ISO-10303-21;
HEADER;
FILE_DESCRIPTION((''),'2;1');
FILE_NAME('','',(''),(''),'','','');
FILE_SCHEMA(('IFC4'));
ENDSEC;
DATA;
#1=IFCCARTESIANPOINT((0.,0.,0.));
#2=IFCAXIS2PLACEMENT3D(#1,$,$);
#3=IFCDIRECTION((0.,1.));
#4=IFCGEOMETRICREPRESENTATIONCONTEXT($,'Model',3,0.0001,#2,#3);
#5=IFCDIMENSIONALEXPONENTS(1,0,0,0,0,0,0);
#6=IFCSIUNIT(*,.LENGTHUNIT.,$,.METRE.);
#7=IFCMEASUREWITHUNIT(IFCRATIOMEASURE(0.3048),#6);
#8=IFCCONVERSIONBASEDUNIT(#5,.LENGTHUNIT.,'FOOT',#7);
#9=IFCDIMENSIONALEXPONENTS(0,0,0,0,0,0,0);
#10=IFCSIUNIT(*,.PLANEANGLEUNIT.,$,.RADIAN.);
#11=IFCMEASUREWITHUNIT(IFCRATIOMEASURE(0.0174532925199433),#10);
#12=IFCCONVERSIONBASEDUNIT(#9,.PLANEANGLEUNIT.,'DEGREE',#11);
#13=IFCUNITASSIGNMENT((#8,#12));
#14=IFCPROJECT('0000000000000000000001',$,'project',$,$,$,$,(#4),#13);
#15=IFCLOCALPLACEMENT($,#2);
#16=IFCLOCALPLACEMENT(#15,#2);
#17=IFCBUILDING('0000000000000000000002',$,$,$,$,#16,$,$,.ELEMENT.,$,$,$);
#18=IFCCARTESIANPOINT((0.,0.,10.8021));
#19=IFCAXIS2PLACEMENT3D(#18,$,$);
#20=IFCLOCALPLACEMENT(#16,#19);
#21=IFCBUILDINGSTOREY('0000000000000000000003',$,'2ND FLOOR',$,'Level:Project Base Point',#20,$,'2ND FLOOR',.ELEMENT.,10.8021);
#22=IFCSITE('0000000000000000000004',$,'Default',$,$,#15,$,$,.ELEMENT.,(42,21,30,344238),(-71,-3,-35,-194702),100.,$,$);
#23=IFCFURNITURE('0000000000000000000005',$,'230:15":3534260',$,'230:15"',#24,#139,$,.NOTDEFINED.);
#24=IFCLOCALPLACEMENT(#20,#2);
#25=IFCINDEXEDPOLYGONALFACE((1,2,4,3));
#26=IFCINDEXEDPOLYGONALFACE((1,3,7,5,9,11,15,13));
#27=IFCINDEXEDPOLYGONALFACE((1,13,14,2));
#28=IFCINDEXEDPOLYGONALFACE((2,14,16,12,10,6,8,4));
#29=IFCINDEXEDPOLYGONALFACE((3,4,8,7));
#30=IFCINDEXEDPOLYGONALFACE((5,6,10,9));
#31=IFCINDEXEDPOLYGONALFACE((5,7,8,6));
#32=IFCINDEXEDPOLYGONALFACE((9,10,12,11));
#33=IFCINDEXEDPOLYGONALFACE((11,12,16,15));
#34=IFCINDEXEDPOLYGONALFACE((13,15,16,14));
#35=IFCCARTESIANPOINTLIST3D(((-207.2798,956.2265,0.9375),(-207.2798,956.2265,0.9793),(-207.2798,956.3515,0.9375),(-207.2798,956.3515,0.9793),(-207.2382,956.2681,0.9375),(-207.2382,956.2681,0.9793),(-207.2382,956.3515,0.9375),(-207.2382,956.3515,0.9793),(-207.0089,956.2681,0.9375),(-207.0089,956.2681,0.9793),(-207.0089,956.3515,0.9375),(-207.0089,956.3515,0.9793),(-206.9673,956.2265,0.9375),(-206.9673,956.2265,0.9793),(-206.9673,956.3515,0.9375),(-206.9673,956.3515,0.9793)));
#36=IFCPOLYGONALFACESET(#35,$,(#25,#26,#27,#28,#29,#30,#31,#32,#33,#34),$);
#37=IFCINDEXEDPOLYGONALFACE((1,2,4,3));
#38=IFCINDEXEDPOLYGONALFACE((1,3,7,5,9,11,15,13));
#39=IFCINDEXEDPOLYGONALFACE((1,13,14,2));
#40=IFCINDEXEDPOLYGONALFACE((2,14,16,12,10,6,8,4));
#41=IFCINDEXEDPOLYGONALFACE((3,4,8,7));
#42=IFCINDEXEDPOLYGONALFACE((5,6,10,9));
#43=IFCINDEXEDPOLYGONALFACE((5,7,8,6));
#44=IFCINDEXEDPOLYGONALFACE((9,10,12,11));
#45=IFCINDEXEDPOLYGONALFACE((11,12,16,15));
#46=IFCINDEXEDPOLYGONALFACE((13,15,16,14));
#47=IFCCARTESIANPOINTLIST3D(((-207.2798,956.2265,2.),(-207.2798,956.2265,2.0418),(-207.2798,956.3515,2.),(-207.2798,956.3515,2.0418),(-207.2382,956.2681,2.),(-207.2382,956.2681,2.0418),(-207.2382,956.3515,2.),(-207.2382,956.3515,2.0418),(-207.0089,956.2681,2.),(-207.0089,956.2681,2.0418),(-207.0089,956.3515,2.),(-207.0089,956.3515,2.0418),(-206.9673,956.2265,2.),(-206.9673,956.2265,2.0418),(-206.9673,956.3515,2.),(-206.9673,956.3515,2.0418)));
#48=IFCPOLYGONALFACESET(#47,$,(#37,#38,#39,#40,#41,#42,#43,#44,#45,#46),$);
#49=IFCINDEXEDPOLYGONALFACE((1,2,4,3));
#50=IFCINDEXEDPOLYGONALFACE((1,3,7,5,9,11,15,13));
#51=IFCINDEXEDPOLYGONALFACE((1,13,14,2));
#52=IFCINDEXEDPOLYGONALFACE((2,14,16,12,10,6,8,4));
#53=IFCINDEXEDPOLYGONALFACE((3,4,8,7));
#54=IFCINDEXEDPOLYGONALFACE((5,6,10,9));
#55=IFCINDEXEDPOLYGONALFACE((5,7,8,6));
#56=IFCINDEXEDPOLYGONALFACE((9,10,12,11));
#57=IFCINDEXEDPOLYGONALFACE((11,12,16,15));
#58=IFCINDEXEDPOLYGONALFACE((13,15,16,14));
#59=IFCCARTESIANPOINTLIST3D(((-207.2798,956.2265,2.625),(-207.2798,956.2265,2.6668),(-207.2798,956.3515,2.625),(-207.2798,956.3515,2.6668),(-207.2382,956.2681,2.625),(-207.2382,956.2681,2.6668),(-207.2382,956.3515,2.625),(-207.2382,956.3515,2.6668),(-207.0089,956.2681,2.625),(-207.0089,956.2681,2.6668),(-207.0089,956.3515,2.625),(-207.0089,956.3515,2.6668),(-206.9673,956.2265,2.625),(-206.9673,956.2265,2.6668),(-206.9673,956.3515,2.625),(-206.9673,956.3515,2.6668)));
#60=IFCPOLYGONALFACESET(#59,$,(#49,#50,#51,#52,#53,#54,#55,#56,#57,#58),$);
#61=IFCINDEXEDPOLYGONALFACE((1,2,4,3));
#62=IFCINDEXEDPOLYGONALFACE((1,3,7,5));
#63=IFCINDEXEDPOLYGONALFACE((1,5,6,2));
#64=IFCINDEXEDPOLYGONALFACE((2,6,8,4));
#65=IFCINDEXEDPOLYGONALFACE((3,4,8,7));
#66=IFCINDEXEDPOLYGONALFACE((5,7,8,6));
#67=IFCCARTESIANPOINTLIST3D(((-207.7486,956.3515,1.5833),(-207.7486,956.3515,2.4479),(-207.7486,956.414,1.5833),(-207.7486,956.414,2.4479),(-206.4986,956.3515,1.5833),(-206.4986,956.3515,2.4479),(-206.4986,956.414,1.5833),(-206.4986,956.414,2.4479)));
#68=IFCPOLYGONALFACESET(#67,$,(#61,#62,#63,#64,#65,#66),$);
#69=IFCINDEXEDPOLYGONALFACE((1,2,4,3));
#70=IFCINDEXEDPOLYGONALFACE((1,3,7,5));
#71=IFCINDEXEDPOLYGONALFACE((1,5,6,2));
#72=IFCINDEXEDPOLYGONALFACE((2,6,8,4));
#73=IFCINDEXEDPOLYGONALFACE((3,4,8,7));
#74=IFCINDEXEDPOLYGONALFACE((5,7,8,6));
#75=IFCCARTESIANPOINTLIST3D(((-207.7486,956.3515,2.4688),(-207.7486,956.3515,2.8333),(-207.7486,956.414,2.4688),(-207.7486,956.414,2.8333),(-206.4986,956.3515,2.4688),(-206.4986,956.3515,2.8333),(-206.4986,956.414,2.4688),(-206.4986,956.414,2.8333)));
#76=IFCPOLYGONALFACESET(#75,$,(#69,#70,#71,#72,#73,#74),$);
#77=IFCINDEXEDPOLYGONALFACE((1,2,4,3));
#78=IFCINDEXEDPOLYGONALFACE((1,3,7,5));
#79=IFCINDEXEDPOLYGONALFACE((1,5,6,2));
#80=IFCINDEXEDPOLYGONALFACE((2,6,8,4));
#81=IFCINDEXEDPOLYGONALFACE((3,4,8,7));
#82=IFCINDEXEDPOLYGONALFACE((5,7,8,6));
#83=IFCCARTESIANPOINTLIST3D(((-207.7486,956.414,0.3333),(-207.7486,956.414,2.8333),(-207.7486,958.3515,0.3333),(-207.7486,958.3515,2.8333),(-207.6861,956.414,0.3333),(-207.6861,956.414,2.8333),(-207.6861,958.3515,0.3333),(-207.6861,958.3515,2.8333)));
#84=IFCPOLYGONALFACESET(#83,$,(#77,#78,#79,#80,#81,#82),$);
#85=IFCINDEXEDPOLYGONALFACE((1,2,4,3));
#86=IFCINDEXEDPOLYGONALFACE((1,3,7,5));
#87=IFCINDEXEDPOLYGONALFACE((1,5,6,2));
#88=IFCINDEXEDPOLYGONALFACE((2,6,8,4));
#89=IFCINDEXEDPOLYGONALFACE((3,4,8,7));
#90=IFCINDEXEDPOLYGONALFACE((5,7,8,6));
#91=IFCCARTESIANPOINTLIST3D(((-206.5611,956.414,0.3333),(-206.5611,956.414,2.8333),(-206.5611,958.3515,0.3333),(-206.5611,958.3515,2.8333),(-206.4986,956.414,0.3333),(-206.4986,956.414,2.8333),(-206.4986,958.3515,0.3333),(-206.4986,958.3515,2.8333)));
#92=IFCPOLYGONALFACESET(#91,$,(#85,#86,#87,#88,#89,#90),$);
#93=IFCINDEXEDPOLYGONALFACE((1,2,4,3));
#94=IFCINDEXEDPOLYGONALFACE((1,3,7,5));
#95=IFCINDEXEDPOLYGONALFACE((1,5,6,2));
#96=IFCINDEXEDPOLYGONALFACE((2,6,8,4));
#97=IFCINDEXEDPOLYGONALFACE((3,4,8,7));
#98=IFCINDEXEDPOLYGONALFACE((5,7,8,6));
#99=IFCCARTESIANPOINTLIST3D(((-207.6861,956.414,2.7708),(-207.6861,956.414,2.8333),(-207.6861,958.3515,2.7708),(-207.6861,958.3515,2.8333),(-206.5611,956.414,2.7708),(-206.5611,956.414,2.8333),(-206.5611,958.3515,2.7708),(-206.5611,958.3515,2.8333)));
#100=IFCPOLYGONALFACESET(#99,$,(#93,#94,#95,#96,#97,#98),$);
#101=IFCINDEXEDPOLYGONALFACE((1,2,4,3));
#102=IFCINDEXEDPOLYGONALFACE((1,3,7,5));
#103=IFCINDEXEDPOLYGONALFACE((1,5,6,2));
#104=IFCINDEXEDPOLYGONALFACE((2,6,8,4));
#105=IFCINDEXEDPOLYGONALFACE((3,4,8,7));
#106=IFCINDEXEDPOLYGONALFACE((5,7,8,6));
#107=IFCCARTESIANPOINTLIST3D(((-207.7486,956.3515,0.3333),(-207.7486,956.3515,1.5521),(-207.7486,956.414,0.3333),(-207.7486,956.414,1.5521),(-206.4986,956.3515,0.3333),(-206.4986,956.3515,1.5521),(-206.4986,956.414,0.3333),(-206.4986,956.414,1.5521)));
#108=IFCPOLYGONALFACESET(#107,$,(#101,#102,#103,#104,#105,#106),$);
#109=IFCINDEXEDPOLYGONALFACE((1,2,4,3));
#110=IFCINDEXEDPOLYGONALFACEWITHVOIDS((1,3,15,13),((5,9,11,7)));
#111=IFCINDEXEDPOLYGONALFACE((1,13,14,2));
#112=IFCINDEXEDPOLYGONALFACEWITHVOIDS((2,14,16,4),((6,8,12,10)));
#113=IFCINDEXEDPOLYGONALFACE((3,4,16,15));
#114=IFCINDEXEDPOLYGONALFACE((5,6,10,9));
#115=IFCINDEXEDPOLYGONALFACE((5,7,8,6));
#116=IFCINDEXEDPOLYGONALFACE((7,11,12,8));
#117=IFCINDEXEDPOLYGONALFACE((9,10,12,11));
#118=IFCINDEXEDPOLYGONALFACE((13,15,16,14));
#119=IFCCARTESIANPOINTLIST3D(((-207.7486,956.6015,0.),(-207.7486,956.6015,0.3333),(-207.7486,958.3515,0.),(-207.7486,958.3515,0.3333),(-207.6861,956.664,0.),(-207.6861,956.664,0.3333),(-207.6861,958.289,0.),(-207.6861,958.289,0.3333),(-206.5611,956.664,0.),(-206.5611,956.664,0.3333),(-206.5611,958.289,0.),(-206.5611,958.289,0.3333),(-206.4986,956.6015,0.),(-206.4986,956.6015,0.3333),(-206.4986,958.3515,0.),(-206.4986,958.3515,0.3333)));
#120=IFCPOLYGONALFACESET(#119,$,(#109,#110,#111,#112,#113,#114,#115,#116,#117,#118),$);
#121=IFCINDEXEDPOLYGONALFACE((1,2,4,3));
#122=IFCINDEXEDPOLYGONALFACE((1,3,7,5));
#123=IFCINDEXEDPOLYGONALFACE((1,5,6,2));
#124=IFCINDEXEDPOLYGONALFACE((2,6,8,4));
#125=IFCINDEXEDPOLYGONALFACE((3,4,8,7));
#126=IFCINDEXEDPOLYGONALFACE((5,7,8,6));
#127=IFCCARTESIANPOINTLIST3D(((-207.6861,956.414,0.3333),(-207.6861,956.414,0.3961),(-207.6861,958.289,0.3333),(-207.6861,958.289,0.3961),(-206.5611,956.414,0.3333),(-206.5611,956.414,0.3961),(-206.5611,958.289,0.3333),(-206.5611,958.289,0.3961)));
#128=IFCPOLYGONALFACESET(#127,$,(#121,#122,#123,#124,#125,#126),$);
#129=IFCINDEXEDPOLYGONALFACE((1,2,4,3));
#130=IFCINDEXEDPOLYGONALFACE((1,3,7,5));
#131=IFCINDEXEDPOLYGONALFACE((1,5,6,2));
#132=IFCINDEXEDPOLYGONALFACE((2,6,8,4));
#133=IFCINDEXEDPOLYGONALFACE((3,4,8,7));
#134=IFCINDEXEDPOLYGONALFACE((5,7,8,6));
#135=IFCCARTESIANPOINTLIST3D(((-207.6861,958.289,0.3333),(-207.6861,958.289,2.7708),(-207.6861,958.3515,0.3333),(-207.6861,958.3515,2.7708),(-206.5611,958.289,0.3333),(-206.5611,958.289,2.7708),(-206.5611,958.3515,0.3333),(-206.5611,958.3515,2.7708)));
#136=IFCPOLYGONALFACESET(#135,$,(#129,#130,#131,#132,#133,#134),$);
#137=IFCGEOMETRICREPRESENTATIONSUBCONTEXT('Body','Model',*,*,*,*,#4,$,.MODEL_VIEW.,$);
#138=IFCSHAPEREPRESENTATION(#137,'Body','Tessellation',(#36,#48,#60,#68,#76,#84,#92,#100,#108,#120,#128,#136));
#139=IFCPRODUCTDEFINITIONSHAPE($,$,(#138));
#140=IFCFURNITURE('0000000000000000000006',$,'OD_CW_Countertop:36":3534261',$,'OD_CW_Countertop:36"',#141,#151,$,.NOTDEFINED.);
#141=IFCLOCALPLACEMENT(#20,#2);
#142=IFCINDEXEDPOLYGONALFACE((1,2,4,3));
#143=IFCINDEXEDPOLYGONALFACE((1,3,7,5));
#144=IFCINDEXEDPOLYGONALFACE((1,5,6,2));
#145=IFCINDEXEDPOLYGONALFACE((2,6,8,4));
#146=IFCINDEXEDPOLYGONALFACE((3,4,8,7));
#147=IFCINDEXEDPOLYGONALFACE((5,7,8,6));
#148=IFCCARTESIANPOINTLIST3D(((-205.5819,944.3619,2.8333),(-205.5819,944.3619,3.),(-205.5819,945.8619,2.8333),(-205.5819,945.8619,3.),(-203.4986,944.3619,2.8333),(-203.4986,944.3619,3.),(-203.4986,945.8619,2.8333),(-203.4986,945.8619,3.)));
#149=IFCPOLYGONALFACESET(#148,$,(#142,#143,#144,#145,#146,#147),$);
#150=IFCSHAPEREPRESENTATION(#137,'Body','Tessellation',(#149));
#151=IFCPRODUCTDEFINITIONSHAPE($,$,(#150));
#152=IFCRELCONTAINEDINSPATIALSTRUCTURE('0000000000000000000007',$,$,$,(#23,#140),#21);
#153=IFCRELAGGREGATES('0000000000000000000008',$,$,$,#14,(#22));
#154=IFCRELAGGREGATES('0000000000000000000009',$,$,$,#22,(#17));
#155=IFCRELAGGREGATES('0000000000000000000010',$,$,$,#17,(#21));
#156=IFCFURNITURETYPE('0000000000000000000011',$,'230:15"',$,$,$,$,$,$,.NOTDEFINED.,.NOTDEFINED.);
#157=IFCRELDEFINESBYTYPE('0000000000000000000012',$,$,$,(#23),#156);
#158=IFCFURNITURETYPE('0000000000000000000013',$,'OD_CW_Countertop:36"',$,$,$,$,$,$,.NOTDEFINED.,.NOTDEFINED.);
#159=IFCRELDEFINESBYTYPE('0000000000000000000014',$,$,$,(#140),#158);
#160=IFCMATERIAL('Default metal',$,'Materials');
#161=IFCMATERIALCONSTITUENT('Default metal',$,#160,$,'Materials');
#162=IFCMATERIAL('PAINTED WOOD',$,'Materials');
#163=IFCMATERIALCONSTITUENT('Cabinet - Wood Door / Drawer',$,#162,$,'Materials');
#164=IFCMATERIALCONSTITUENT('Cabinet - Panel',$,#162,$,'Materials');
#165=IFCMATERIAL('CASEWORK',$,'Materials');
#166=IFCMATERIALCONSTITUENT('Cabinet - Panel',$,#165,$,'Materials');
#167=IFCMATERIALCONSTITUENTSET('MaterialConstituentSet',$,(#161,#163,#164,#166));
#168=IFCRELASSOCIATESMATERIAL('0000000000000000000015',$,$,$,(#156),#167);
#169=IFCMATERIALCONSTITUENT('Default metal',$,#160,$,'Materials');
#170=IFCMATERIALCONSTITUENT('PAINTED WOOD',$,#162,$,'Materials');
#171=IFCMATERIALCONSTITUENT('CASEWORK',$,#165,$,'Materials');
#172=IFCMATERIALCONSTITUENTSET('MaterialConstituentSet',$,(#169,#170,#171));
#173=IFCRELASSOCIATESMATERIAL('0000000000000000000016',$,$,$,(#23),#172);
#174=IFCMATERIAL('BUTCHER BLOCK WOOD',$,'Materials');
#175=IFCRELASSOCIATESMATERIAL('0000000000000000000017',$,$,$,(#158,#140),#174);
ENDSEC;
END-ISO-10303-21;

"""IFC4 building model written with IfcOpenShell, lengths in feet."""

from ifc_helpers import new_model, entity, si_unit, converted_unit, direction, frame, frame_2d, origin, origin_2d_with_axis, place, context, subcontext, project, spatial, polyline, rectangle, outline, extrude, source, transform, mapped, material, constituent, constituent_set, type_object, type_shapes, element, save


model = new_model("IFC4")

# Units and contexts
model_context = context("Model", 3, precision=0.0001, world=origin(), true_north=direction((0.0, 1.0)))
body_context = subcontext(model_context, "Body", "Model", "MODEL_VIEW")
ifc_project = project(units=[converted_unit("LENGTHUNIT", "FOOT", entity("IfcRatioMeasure", 0.3048), si_unit("LENGTHUNIT", "METRE"), dimensions=[1, 0, 0, 0, 0, 0, 0]), converted_unit("PLANEANGLEUNIT", "DEGREE", entity("IfcRatioMeasure", 0.0174532925199433), si_unit("PLANEANGLEUNIT", "RADIAN"), dimensions=[0, 0, 0, 0, 0, 0, 0])], contexts=[model_context])

# Site, building, storey
site_placement = place(None, origin())
site = spatial("IfcSite", under=ifc_project, at=site_placement, Name="Default", CompositionType="ELEMENT", RefLatitude=(42, 21, 30, 344238), RefLongitude=(-71, -3, -35, -194702), RefElevation=100.0)
building_placement = place(site_placement, origin())
building = spatial("IfcBuilding", under=site, at=building_placement, CompositionType="ELEMENT")
storey_placement = place(building_placement, frame((0.0, 0.0, 10.8021)))
storey = spatial("IfcBuildingStorey", under=building, at=storey_placement, Name="2ND FLOOR", ObjectType="Level:Project Base Point", LongName="2ND FLOOR", CompositionType="ELEMENT", Elevation=10.8021)

# Furniture
ifc_material_1 = material(Name="CASEWORK", Category="Materials")
ifc_material_2 = material(Name="PAINTED WOOD", Category="Materials")
ifc_material_3 = material(Name="Default metal", Category="Materials")
ifc_material_4 = material(Name="BUTCHER BLOCK WOOD", Category="Materials")
ifc_constituent_1 = constituent(ifc_material_3, Name="Default metal", Category="Materials")
ifc_constituent_2 = constituent(ifc_material_2, Name="PAINTED WOOD", Category="Materials")
ifc_constituent_3 = constituent(ifc_material_1, Name="CASEWORK", Category="Materials")
ifc_constituent_set_1 = constituent_set(constituents=[ifc_constituent_1, ifc_constituent_2, ifc_constituent_3], Name="MaterialConstituentSet")
ifc_constituent_4 = constituent(ifc_material_3, Name="Default metal", Category="Materials")
ifc_constituent_5 = constituent(ifc_material_2, Name="Cabinet - Wood Door / Drawer", Category="Materials")
ifc_constituent_6 = constituent(ifc_material_2, Name="Cabinet - Panel", Category="Materials")
ifc_constituent_7 = constituent(ifc_material_1, Name="Cabinet - Panel", Category="Materials")
ifc_constituent_set_2 = constituent_set(constituents=[ifc_constituent_4, ifc_constituent_5, ifc_constituent_6, ifc_constituent_7], Name="MaterialConstituentSet")
furniture_type_1 = type_object("IfcFurnitureType", Name="230:15\"", AssemblyPlace="NOTDEFINED", PredefinedType="NOTDEFINED", material=ifc_constituent_set_2)
shared_shape_1 = source(origin(), body_context, "Body", "SweptSolid", [
    extrude(outline(polyline([(-0.0521, -0.1562), (0.0729, -0.1562), (0.0729, 0.1562), (-0.0521, 0.1562), (-0.0521, 0.1146), (0.0313, 0.1146), (0.0313, -0.1146), (-0.0521, -0.1146), (-0.0521, -0.1562)])), frame((0.0615, -2.0521, 0.9375), z_axis=(0.0, 0.0, 1.0), x_axis=(0.0, -1.0, 0.0)), (0.0, 0.0, 1.0), 0.0418),
    extrude(outline(polyline([(-0.0521, -0.1562), (0.0729, -0.1562), (0.0729, 0.1562), (-0.0521, 0.1562), (-0.0521, 0.1146), (0.0313, 0.1146), (0.0313, -0.1146), (-0.0521, -0.1146), (-0.0521, -0.1562)])), frame((0.0615, -2.0521, 2.0), z_axis=(0.0, 0.0, 1.0), x_axis=(0.0, -1.0, 0.0)), (0.0, 0.0, 1.0), 0.0418),
    extrude(outline(polyline([(-0.0521, -0.1562), (0.0729, -0.1562), (0.0729, 0.1562), (-0.0521, 0.1562), (-0.0521, 0.1146), (0.0313, 0.1146), (0.0313, -0.1146), (-0.0521, -0.1146), (-0.0521, -0.1562)])), frame((0.0615, -2.0521, 2.625), z_axis=(0.0, 0.0, 1.0), x_axis=(0.0, -1.0, 0.0)), (0.0, 0.0, 1.0), 0.0418),
    extrude(rectangle(XDim=0.0625, YDim=1.25, at=frame_2d((0.0, 0.0), x_axis=(1.0, 0.0))), frame((0.0615, -1.9688, 1.5833), z_axis=(0.0, 0.0, 1.0), x_axis=(0.0, 1.0, 0.0)), (0.0, 0.0, 1.0), 0.8646),
    extrude(rectangle(XDim=0.0625, YDim=1.25, at=frame_2d((0.0, 0.0), x_axis=(1.0, 0.0))), frame((0.0615, -1.9688, 2.4688), z_axis=(0.0, 0.0, 1.0), x_axis=(0.0, 1.0, 0.0)), (0.0, 0.0, 1.0), 0.3646),
    extrude(rectangle(XDim=0.0625, YDim=1.9375, at=frame_2d((0.0, 0.0), x_axis=(1.0, 0.0))), frame((-0.5323, -0.9687, 0.3333)), (0.0, 0.0, 1.0), 2.5),
    extrude(rectangle(XDim=0.0625, YDim=1.9375, at=frame_2d((0.0, 0.0), x_axis=(1.0, 0.0))), frame((0.6552, -0.9687, 0.3333)), (0.0, 0.0, 1.0), 2.5),
    extrude(rectangle(XDim=1.125, YDim=1.9375, at=origin_2d_with_axis()), frame((0.0615, -0.9687, 2.7708), z_axis=(0.0, 0.0, 1.0), x_axis=(-1.0, 0.0, 0.0)), (0.0, 0.0, 1.0), 0.0625),
    extrude(rectangle(XDim=0.0625, YDim=1.25, at=frame_2d((0.0, 0.0), x_axis=(1.0, 0.0))), frame((0.0615, -1.9688, 0.3333), z_axis=(0.0, 0.0, 1.0), x_axis=(0.0, 1.0, 0.0)), (0.0, 0.0, 1.0), 1.2187),
    extrude(outline(polyline([(-0.625, -0.875), (0.625, -0.875), (0.625, 0.875), (-0.625, 0.875), (-0.625, -0.875)]), holes=[polyline([(-0.5625, -0.8125), (-0.5625, 0.8125), (0.5625, 0.8125), (0.5625, -0.8125), (-0.5625, -0.8125)])]), frame((0.0615, -0.875, 0.0)), (0.0, 0.0, 1.0), 0.3333),
    extrude(rectangle(XDim=1.125, YDim=1.875, at=frame_2d((0.0, 0.0), x_axis=(1.0, 0.0))), frame((0.0615, -1.0, 0.3333), z_axis=(0.0, 0.0, 1.0), x_axis=(-1.0, 0.0, 0.0)), (0.0, 0.0, 1.0), 0.0627),
    extrude(rectangle(XDim=0.0625, YDim=1.125, at=origin_2d_with_axis()), frame((0.0615, -0.0312, 0.3333), z_axis=(0.0, 0.0, 1.0), x_axis=(0.0, 1.0, 0.0)), (0.0, 0.0, 1.0), 2.4375),
])
type_shapes(furniture_type_1, [shared_shape_1])
furniture_1_placement = place(storey_placement, frame((-207.1851, 958.3515, 0.0)))
element("IfcFurniture", 1, at=furniture_1_placement, inside=storey, type_object=furniture_type_1, material=ifc_constituent_set_1, Name="230:15\":3534260", ObjectType="230:15\"", PredefinedType="NOTDEFINED", context=body_context, shape_type="MappedRepresentation", body=[
    mapped(shared_shape_1, transform((0.0, 0.0, 0.0), scale=1.0)),
])
furniture_type_2 = type_object("IfcFurnitureType", Name="OD_CW_Countertop:36\"", AssemblyPlace="NOTDEFINED", PredefinedType="NOTDEFINED", material=ifc_material_4)
shared_shape_2 = source(origin(), body_context, "Body", "SweptSolid", [
    extrude(rectangle(XDim=1.5, YDim=2.0833, at=origin_2d_with_axis()), frame((0.75, 1.0417, 0.0)), (0.0, 0.0, 1.0), 0.1667),
])
type_shapes(furniture_type_2, [shared_shape_2])
furniture_2_placement = place(storey_placement, frame((-203.4986, 944.3619, 2.8333), z_axis=(0.0, 0.0, 1.0), x_axis=(0.0, 1.0, 0.0)))
element("IfcFurniture", 2, at=furniture_2_placement, inside=storey, type_object=furniture_type_2, material=ifc_material_4, Name="OD_CW_Countertop:36\":3534261", ObjectType="OD_CW_Countertop:36\"", PredefinedType="NOTDEFINED", context=body_context, shape_type="MappedRepresentation", body=[
    mapped(shared_shape_2, transform((0.0, 0.0, 0.0), scale=1.0)),
])

save(model, "model.ifc")
